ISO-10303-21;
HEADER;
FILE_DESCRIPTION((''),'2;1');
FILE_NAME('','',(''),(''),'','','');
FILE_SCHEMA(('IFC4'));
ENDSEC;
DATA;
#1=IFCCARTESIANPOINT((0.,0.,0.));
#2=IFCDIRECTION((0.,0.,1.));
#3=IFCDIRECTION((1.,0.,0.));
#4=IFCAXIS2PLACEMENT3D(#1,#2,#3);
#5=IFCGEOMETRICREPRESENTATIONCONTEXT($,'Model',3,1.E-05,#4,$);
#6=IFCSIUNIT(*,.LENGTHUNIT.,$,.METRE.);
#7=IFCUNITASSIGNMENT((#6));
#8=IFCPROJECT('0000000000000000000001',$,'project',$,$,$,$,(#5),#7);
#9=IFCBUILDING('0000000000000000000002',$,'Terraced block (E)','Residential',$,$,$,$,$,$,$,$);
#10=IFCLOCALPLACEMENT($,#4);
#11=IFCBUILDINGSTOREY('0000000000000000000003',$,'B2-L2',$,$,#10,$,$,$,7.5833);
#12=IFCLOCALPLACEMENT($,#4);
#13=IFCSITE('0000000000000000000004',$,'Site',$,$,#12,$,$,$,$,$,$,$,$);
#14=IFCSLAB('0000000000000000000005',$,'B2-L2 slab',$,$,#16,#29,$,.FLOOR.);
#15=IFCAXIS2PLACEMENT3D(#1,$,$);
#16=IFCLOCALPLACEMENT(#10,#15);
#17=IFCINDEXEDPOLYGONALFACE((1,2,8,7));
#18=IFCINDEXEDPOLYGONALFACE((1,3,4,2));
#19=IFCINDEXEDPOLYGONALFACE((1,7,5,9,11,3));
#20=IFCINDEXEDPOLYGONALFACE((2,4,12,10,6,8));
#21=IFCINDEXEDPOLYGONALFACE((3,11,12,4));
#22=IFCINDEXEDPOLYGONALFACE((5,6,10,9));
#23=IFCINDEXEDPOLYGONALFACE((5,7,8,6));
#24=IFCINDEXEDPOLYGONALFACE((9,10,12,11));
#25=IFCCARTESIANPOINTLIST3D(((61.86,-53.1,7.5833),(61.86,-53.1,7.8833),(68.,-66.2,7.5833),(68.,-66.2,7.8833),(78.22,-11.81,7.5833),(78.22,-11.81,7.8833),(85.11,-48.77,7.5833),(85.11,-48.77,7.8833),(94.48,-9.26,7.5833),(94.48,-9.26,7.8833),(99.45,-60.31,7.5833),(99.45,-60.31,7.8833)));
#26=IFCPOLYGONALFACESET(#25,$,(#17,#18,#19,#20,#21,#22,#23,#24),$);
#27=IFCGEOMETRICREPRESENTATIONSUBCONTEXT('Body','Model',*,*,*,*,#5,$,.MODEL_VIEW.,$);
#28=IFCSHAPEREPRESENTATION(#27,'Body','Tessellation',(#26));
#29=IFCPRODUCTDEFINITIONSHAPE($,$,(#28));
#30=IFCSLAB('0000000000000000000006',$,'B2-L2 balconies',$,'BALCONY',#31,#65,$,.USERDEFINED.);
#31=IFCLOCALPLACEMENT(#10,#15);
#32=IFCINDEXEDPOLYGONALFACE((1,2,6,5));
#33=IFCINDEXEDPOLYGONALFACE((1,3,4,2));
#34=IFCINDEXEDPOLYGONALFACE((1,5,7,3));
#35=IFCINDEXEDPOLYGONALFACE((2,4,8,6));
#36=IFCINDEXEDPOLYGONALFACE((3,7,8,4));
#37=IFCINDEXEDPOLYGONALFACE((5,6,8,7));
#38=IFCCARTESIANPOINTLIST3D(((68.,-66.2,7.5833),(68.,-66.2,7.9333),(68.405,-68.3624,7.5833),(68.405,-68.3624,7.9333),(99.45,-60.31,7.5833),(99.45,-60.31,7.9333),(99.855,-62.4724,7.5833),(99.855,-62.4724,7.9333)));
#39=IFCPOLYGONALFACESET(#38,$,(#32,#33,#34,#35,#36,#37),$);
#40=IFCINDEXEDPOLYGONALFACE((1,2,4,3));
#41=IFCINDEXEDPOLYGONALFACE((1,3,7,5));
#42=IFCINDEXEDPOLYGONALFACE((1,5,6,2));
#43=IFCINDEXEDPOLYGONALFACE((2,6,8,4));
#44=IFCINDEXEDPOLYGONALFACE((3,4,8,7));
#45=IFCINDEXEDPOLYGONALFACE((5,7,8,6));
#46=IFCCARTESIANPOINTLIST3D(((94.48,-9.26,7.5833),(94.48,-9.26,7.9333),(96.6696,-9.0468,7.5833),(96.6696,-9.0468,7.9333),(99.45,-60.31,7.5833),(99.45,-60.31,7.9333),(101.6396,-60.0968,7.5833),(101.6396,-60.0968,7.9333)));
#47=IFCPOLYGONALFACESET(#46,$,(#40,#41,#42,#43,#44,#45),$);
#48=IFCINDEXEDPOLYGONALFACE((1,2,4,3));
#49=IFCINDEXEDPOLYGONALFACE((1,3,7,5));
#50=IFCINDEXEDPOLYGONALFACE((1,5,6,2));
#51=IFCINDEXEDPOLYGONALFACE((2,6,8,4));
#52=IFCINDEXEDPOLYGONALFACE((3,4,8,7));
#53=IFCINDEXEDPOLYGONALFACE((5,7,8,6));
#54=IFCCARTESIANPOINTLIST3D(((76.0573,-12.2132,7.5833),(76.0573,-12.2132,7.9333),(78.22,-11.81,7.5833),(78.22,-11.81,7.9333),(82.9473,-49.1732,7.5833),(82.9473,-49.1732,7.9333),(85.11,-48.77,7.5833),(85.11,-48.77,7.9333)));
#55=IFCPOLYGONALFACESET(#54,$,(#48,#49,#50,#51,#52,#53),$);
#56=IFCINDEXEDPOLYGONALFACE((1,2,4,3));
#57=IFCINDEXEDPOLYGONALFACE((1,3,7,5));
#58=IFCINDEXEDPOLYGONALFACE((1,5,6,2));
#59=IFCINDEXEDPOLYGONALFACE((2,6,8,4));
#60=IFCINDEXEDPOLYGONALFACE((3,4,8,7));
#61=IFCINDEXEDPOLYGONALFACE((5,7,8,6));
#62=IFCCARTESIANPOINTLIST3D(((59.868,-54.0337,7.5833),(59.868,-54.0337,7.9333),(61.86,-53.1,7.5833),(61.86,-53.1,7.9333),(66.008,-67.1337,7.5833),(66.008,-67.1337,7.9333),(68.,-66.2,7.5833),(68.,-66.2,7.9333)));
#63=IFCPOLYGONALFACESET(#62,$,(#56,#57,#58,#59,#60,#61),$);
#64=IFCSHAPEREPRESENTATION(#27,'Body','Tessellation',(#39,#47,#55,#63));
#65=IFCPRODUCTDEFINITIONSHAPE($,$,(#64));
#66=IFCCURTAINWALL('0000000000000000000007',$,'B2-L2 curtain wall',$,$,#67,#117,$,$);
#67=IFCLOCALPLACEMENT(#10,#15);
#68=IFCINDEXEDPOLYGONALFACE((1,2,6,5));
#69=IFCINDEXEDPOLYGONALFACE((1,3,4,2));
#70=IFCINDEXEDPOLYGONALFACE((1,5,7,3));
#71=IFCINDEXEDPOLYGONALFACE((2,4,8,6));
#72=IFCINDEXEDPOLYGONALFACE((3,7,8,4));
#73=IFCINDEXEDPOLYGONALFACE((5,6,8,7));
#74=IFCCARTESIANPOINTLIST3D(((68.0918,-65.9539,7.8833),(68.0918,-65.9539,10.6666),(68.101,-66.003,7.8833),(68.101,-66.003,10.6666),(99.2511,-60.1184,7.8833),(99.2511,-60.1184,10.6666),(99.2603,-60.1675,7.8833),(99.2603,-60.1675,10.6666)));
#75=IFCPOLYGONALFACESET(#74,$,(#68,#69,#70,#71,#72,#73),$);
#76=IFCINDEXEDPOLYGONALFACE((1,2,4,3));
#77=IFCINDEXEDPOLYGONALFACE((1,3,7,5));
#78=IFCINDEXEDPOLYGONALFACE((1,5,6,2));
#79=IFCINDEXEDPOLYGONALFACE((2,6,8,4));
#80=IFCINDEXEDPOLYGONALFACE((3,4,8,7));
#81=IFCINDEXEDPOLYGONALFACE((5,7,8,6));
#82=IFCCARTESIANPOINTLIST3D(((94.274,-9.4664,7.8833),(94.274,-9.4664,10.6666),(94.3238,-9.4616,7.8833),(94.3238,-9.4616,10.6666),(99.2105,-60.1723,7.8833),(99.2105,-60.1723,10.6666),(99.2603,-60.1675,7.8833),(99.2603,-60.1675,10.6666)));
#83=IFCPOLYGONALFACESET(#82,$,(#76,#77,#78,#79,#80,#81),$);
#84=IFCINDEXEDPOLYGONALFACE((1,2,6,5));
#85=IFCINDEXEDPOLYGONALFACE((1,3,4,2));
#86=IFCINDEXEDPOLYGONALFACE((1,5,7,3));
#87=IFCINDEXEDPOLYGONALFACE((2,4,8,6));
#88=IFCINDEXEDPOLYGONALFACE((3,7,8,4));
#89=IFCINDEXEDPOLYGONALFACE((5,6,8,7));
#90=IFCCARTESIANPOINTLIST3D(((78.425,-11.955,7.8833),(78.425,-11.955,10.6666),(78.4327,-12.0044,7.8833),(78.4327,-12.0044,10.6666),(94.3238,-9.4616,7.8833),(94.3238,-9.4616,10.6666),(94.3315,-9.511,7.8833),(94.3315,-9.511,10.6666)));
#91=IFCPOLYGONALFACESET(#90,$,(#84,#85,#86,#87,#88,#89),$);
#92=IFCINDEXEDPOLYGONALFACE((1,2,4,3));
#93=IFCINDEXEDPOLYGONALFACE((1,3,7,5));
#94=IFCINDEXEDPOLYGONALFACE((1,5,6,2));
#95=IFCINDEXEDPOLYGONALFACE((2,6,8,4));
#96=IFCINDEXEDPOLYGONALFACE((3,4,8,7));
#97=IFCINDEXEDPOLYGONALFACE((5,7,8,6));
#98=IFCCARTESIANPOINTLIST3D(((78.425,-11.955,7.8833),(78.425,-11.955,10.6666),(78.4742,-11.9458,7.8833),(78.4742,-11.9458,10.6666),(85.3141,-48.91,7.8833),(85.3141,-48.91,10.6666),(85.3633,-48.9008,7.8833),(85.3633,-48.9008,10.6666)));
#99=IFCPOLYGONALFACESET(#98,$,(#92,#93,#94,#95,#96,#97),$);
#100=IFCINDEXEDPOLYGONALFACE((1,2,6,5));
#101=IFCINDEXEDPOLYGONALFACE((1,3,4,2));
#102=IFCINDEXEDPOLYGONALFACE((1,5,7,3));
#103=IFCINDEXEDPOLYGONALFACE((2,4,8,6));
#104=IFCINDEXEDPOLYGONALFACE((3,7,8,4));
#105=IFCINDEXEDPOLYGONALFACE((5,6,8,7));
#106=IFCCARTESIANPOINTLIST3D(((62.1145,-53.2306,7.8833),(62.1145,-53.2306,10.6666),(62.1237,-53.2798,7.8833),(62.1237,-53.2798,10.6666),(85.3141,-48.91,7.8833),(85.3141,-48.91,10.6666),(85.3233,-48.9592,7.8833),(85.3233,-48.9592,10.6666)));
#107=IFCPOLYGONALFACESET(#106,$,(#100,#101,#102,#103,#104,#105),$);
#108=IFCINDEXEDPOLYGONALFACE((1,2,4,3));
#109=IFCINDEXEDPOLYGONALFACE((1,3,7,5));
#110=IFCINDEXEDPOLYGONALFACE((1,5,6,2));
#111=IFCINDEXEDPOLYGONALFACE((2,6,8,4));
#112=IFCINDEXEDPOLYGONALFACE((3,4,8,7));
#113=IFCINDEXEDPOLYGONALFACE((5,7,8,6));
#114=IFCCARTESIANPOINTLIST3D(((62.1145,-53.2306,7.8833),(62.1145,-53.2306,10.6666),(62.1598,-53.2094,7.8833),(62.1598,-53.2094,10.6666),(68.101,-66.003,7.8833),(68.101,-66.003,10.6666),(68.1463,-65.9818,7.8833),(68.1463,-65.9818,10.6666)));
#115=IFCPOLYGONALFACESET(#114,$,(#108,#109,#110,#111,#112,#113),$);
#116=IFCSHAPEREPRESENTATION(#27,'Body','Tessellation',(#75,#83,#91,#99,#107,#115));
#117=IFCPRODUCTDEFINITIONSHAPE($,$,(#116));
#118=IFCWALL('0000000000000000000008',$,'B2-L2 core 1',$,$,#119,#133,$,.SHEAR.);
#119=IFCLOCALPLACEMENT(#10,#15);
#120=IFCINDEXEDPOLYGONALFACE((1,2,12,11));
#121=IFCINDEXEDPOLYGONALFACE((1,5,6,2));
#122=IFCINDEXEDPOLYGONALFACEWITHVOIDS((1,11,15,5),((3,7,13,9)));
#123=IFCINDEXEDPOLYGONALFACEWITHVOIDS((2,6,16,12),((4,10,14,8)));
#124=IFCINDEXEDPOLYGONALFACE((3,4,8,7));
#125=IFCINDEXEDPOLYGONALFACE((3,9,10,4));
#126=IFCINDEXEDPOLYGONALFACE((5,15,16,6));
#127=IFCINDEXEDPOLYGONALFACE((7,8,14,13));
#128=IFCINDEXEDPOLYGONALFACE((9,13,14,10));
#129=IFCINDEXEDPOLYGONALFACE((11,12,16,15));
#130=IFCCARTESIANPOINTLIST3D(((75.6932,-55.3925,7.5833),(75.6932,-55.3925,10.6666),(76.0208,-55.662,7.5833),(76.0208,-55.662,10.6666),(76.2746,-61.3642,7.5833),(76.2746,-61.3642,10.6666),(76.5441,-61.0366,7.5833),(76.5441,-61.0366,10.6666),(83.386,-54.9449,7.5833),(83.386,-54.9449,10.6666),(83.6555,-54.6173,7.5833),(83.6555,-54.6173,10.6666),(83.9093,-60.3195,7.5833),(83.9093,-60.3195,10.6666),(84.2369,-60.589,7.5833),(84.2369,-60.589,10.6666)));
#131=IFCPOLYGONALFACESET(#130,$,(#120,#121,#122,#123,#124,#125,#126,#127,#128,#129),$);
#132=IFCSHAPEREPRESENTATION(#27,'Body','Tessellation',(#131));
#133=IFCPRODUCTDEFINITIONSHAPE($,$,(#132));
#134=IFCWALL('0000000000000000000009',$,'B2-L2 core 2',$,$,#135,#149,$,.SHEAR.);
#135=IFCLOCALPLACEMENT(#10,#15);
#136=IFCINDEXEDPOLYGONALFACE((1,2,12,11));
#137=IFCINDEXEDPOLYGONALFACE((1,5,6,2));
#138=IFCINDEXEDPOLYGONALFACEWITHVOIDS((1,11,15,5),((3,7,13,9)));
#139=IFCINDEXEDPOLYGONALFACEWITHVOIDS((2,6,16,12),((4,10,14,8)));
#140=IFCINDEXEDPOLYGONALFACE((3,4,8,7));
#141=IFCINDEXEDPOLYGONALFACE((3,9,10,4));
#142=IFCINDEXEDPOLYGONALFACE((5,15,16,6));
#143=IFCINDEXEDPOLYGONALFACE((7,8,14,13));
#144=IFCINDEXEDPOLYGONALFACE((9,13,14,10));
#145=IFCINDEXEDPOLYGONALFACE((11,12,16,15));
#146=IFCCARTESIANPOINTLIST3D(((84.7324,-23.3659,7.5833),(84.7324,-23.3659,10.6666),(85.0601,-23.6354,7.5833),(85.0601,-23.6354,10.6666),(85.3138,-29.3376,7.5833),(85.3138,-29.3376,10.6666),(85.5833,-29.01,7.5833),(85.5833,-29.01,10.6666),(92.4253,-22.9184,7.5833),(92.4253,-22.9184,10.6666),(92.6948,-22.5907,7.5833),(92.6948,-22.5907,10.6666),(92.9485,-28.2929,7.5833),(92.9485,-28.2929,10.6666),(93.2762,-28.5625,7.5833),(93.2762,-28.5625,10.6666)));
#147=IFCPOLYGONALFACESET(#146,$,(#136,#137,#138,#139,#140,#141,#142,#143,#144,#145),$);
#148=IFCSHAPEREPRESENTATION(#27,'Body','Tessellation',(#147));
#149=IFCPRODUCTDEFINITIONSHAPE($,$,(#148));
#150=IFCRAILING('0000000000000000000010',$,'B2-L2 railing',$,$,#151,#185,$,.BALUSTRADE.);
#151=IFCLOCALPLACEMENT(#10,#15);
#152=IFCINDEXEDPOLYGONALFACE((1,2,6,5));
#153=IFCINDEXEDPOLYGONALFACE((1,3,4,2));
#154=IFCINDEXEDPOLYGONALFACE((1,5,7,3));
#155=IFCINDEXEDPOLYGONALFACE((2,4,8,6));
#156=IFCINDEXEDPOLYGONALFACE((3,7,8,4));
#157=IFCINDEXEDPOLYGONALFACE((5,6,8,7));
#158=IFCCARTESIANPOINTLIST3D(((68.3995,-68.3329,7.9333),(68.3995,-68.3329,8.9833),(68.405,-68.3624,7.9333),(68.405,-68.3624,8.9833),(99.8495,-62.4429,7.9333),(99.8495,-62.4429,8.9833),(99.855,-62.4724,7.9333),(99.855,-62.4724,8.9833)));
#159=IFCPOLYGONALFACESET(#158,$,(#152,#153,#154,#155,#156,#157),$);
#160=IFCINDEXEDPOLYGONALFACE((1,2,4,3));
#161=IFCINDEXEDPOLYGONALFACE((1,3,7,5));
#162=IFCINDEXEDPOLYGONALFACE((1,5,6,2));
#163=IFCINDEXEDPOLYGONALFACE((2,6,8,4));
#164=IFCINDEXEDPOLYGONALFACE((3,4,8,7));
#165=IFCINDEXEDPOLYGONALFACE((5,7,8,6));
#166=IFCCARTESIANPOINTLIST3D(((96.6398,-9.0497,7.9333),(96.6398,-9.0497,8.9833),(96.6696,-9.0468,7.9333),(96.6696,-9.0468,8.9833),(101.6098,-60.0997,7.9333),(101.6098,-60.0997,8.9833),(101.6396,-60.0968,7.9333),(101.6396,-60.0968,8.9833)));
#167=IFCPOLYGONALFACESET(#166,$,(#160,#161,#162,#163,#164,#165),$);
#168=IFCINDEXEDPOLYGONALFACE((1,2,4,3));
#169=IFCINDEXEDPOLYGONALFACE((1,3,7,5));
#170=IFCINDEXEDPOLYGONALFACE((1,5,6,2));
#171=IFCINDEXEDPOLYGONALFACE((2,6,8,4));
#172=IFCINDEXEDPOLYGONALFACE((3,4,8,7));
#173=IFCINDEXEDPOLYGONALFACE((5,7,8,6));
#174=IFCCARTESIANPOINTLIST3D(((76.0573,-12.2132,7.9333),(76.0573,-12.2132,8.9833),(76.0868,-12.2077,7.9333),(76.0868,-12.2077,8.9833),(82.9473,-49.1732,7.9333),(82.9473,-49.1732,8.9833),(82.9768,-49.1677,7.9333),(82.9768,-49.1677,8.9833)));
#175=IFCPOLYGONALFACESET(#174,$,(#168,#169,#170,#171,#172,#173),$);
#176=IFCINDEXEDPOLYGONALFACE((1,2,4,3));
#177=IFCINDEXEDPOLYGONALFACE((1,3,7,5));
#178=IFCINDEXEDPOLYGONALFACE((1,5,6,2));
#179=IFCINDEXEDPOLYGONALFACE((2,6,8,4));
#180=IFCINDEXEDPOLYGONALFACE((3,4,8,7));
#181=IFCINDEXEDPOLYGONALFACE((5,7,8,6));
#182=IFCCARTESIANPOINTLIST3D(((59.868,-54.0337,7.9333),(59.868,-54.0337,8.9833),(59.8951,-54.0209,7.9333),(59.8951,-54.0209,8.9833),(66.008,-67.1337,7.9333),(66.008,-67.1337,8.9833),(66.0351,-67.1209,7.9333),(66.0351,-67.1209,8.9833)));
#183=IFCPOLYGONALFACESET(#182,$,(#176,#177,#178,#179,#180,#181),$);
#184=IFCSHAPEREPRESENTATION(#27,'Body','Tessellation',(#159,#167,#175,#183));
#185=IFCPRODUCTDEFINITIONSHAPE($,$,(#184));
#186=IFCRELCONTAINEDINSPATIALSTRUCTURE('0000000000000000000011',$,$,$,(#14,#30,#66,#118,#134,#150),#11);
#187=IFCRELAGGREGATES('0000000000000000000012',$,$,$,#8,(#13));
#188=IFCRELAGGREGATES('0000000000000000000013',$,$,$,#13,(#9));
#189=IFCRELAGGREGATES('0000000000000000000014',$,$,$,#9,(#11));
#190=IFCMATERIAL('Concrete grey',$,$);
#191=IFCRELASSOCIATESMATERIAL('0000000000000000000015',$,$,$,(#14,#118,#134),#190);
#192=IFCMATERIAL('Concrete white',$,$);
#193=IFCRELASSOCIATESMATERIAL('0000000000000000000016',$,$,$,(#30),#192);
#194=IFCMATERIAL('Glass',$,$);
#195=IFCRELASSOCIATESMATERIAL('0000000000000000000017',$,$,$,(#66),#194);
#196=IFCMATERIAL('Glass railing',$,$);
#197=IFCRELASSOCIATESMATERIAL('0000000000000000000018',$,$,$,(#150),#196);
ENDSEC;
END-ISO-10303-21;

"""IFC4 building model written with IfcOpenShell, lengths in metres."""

from ifc_helpers import new_model, si_unit, frame, origin_with_axes, place, context, subcontext, project, spatial, polyline, outline, extrude, material, element, save


model = new_model("IFC4")

# Units and contexts
model_context = context("Model", 3, precision=1e-05, world=origin_with_axes())
body_context = subcontext(model_context, "Body", "Model", "MODEL_VIEW")
ifc_project = project(units=[si_unit("LENGTHUNIT", "METRE")], contexts=[model_context])

# Site, building, storey
site_placement = place(None, origin_with_axes())
site = spatial("IfcSite", under=ifc_project, at=site_placement, Name="Site")
building = spatial("IfcBuilding", under=site, Name="Terraced block (E)", Description="Residential")
storey_placement = place(None, origin_with_axes())
storey = spatial("IfcBuildingStorey", under=building, at=storey_placement, Name="B2-L2", Elevation=7.5833)

# Slabs
ifc_material_1 = material(Name="Concrete grey")
slab_1_placement = place(storey_placement, origin_with_axes())
element("IfcSlab", 1, at=slab_1_placement, inside=storey, material=ifc_material_1, Name="B2-L2 slab", PredefinedType="FLOOR", context=body_context, shape_type="SweptSolid", body=[
    extrude(outline(polyline([(68.0, -66.2), (99.45, -60.31), (94.48, -9.26), (78.22, -11.81), (85.11, -48.77), (61.86, -53.1), (68.0, -66.2)])), frame((0.0, 0.0, 7.5833), z_axis=(0.0, 0.0, 1.0), x_axis=(1.0, 0.0, 0.0)), (0.0, 0.0, 1.0), 0.3),
])
ifc_material_2 = material(Name="Concrete white")
slab_2_placement = place(storey_placement, origin_with_axes())
element("IfcSlab", 2, at=slab_2_placement, inside=storey, material=ifc_material_2, Name="B2-L2 balconies", ObjectType="BALCONY", PredefinedType="USERDEFINED", context=body_context, shape_type="SweptSolid", body=[
    extrude(outline(polyline([(68.0, -66.2), (99.45, -60.31), (99.855, -62.4724), (68.405, -68.3624), (68.0, -66.2)])), frame((0.0, 0.0, 7.5833), z_axis=(0.0, 0.0, 1.0), x_axis=(1.0, 0.0, 0.0)), (0.0, 0.0, 1.0), 0.35),
    extrude(outline(polyline([(99.45, -60.31), (94.48, -9.26), (96.6696, -9.0468), (101.6396, -60.0968), (99.45, -60.31)])), frame((0.0, 0.0, 7.5833), z_axis=(0.0, 0.0, 1.0), x_axis=(1.0, 0.0, 0.0)), (0.0, 0.0, 1.0), 0.35),
    extrude(outline(polyline([(78.22, -11.81), (85.11, -48.77), (82.9473, -49.1732), (76.0573, -12.2132), (78.22, -11.81)])), frame((0.0, 0.0, 7.5833), z_axis=(0.0, 0.0, 1.0), x_axis=(1.0, 0.0, 0.0)), (0.0, 0.0, 1.0), 0.35),
    extrude(outline(polyline([(61.86, -53.1), (68.0, -66.2), (66.008, -67.1337), (59.868, -54.0337), (61.86, -53.1)])), frame((0.0, 0.0, 7.5833), z_axis=(0.0, 0.0, 1.0), x_axis=(1.0, 0.0, 0.0)), (0.0, 0.0, 1.0), 0.35),
])

# Curtain wall
ifc_material_3 = material(Name="Glass")
curtain_wall_placement = place(storey_placement, origin_with_axes())
element("IfcCurtainWall", 3, at=curtain_wall_placement, inside=storey, material=ifc_material_3, Name="B2-L2 curtain wall", context=body_context, shape_type="SweptSolid", body=[
    extrude(outline(polyline([(68.101, -66.003), (99.2603, -60.1675), (99.2511, -60.1184), (68.0918, -65.9539), (68.101, -66.003)])), frame((0.0, 0.0, 7.8833), z_axis=(0.0, 0.0, 1.0), x_axis=(1.0, 0.0, 0.0)), (0.0, 0.0, 1.0), 2.7833),
    extrude(outline(polyline([(99.2603, -60.1675), (94.3238, -9.4616), (94.274, -9.4664), (99.2105, -60.1723), (99.2603, -60.1675)])), frame((0.0, 0.0, 7.8833), z_axis=(0.0, 0.0, 1.0), x_axis=(1.0, 0.0, 0.0)), (0.0, 0.0, 1.0), 2.7833),
    extrude(outline(polyline([(94.3238, -9.4616), (78.425, -11.955), (78.4327, -12.0044), (94.3315, -9.511), (94.3238, -9.4616)])), frame((0.0, 0.0, 7.8833), z_axis=(0.0, 0.0, 1.0), x_axis=(1.0, 0.0, 0.0)), (0.0, 0.0, 1.0), 2.7833),
    extrude(outline(polyline([(78.425, -11.955), (85.3141, -48.91), (85.3633, -48.9008), (78.4742, -11.9458), (78.425, -11.955)])), frame((0.0, 0.0, 7.8833), z_axis=(0.0, 0.0, 1.0), x_axis=(1.0, 0.0, 0.0)), (0.0, 0.0, 1.0), 2.7833),
    extrude(outline(polyline([(85.3141, -48.91), (62.1145, -53.2306), (62.1237, -53.2798), (85.3233, -48.9592), (85.3141, -48.91)])), frame((0.0, 0.0, 7.8833), z_axis=(0.0, 0.0, 1.0), x_axis=(1.0, 0.0, 0.0)), (0.0, 0.0, 1.0), 2.7833),
    extrude(outline(polyline([(62.1145, -53.2306), (68.101, -66.003), (68.1463, -65.9818), (62.1598, -53.2094), (62.1145, -53.2306)])), frame((0.0, 0.0, 7.8833), z_axis=(0.0, 0.0, 1.0), x_axis=(1.0, 0.0, 0.0)), (0.0, 0.0, 1.0), 2.7833),
])

# Walls
wall_1_placement = place(storey_placement, origin_with_axes())
element("IfcWall", 4, at=wall_1_placement, inside=storey, material=ifc_material_1, Name="B2-L2 core 1", PredefinedType="SHEAR", context=body_context, shape_type="SweptSolid", body=[
    extrude(outline(polyline([(84.2369, -60.589), (83.6555, -54.6173), (75.6932, -55.3925), (76.2746, -61.3642), (84.2369, -60.589)]), holes=[polyline([(83.9093, -60.3195), (83.386, -54.9449), (76.0208, -55.662), (76.5441, -61.0366), (83.9093, -60.3195)])]), frame((0.0, 0.0, 7.5833), z_axis=(0.0, 0.0, 1.0), x_axis=(1.0, 0.0, 0.0)), (0.0, 0.0, 1.0), 3.0833),
])
wall_2_placement = place(storey_placement, origin_with_axes())
element("IfcWall", 5, at=wall_2_placement, inside=storey, material=ifc_material_1, Name="B2-L2 core 2", PredefinedType="SHEAR", context=body_context, shape_type="SweptSolid", body=[
    extrude(outline(polyline([(93.2762, -28.5625), (92.6948, -22.5907), (84.7324, -23.3659), (85.3138, -29.3376), (93.2762, -28.5625)]), holes=[polyline([(92.9485, -28.2929), (92.4253, -22.9184), (85.0601, -23.6354), (85.5833, -29.01), (92.9485, -28.2929)])]), frame((0.0, 0.0, 7.5833), z_axis=(0.0, 0.0, 1.0), x_axis=(1.0, 0.0, 0.0)), (0.0, 0.0, 1.0), 3.0833),
])

# Railing
ifc_material_4 = material(Name="Glass railing")
railing_placement = place(storey_placement, origin_with_axes())
element("IfcRailing", 6, at=railing_placement, inside=storey, material=ifc_material_4, Name="B2-L2 railing", PredefinedType="BALUSTRADE", context=body_context, shape_type="SweptSolid", body=[
    extrude(outline(polyline([(68.405, -68.3624), (99.855, -62.4724), (99.8495, -62.4429), (68.3995, -68.3329), (68.405, -68.3624)])), frame((0.0, 0.0, 7.9333), z_axis=(0.0, 0.0, 1.0), x_axis=(1.0, 0.0, 0.0)), (0.0, 0.0, 1.0), 1.05),
    extrude(outline(polyline([(101.6396, -60.0968), (96.6696, -9.0468), (96.6398, -9.0497), (101.6098, -60.0997), (101.6396, -60.0968)])), frame((0.0, 0.0, 7.9333), z_axis=(0.0, 0.0, 1.0), x_axis=(1.0, 0.0, 0.0)), (0.0, 0.0, 1.0), 1.05),
    extrude(outline(polyline([(76.0573, -12.2132), (82.9473, -49.1732), (82.9768, -49.1677), (76.0868, -12.2077), (76.0573, -12.2132)])), frame((0.0, 0.0, 7.9333), z_axis=(0.0, 0.0, 1.0), x_axis=(1.0, 0.0, 0.0)), (0.0, 0.0, 1.0), 1.05),
    extrude(outline(polyline([(59.868, -54.0337), (66.008, -67.1337), (66.0351, -67.1209), (59.8951, -54.0209), (59.868, -54.0337)])), frame((0.0, 0.0, 7.9333), z_axis=(0.0, 0.0, 1.0), x_axis=(1.0, 0.0, 0.0)), (0.0, 0.0, 1.0), 1.05),
])

save(model, "model.ifc")
